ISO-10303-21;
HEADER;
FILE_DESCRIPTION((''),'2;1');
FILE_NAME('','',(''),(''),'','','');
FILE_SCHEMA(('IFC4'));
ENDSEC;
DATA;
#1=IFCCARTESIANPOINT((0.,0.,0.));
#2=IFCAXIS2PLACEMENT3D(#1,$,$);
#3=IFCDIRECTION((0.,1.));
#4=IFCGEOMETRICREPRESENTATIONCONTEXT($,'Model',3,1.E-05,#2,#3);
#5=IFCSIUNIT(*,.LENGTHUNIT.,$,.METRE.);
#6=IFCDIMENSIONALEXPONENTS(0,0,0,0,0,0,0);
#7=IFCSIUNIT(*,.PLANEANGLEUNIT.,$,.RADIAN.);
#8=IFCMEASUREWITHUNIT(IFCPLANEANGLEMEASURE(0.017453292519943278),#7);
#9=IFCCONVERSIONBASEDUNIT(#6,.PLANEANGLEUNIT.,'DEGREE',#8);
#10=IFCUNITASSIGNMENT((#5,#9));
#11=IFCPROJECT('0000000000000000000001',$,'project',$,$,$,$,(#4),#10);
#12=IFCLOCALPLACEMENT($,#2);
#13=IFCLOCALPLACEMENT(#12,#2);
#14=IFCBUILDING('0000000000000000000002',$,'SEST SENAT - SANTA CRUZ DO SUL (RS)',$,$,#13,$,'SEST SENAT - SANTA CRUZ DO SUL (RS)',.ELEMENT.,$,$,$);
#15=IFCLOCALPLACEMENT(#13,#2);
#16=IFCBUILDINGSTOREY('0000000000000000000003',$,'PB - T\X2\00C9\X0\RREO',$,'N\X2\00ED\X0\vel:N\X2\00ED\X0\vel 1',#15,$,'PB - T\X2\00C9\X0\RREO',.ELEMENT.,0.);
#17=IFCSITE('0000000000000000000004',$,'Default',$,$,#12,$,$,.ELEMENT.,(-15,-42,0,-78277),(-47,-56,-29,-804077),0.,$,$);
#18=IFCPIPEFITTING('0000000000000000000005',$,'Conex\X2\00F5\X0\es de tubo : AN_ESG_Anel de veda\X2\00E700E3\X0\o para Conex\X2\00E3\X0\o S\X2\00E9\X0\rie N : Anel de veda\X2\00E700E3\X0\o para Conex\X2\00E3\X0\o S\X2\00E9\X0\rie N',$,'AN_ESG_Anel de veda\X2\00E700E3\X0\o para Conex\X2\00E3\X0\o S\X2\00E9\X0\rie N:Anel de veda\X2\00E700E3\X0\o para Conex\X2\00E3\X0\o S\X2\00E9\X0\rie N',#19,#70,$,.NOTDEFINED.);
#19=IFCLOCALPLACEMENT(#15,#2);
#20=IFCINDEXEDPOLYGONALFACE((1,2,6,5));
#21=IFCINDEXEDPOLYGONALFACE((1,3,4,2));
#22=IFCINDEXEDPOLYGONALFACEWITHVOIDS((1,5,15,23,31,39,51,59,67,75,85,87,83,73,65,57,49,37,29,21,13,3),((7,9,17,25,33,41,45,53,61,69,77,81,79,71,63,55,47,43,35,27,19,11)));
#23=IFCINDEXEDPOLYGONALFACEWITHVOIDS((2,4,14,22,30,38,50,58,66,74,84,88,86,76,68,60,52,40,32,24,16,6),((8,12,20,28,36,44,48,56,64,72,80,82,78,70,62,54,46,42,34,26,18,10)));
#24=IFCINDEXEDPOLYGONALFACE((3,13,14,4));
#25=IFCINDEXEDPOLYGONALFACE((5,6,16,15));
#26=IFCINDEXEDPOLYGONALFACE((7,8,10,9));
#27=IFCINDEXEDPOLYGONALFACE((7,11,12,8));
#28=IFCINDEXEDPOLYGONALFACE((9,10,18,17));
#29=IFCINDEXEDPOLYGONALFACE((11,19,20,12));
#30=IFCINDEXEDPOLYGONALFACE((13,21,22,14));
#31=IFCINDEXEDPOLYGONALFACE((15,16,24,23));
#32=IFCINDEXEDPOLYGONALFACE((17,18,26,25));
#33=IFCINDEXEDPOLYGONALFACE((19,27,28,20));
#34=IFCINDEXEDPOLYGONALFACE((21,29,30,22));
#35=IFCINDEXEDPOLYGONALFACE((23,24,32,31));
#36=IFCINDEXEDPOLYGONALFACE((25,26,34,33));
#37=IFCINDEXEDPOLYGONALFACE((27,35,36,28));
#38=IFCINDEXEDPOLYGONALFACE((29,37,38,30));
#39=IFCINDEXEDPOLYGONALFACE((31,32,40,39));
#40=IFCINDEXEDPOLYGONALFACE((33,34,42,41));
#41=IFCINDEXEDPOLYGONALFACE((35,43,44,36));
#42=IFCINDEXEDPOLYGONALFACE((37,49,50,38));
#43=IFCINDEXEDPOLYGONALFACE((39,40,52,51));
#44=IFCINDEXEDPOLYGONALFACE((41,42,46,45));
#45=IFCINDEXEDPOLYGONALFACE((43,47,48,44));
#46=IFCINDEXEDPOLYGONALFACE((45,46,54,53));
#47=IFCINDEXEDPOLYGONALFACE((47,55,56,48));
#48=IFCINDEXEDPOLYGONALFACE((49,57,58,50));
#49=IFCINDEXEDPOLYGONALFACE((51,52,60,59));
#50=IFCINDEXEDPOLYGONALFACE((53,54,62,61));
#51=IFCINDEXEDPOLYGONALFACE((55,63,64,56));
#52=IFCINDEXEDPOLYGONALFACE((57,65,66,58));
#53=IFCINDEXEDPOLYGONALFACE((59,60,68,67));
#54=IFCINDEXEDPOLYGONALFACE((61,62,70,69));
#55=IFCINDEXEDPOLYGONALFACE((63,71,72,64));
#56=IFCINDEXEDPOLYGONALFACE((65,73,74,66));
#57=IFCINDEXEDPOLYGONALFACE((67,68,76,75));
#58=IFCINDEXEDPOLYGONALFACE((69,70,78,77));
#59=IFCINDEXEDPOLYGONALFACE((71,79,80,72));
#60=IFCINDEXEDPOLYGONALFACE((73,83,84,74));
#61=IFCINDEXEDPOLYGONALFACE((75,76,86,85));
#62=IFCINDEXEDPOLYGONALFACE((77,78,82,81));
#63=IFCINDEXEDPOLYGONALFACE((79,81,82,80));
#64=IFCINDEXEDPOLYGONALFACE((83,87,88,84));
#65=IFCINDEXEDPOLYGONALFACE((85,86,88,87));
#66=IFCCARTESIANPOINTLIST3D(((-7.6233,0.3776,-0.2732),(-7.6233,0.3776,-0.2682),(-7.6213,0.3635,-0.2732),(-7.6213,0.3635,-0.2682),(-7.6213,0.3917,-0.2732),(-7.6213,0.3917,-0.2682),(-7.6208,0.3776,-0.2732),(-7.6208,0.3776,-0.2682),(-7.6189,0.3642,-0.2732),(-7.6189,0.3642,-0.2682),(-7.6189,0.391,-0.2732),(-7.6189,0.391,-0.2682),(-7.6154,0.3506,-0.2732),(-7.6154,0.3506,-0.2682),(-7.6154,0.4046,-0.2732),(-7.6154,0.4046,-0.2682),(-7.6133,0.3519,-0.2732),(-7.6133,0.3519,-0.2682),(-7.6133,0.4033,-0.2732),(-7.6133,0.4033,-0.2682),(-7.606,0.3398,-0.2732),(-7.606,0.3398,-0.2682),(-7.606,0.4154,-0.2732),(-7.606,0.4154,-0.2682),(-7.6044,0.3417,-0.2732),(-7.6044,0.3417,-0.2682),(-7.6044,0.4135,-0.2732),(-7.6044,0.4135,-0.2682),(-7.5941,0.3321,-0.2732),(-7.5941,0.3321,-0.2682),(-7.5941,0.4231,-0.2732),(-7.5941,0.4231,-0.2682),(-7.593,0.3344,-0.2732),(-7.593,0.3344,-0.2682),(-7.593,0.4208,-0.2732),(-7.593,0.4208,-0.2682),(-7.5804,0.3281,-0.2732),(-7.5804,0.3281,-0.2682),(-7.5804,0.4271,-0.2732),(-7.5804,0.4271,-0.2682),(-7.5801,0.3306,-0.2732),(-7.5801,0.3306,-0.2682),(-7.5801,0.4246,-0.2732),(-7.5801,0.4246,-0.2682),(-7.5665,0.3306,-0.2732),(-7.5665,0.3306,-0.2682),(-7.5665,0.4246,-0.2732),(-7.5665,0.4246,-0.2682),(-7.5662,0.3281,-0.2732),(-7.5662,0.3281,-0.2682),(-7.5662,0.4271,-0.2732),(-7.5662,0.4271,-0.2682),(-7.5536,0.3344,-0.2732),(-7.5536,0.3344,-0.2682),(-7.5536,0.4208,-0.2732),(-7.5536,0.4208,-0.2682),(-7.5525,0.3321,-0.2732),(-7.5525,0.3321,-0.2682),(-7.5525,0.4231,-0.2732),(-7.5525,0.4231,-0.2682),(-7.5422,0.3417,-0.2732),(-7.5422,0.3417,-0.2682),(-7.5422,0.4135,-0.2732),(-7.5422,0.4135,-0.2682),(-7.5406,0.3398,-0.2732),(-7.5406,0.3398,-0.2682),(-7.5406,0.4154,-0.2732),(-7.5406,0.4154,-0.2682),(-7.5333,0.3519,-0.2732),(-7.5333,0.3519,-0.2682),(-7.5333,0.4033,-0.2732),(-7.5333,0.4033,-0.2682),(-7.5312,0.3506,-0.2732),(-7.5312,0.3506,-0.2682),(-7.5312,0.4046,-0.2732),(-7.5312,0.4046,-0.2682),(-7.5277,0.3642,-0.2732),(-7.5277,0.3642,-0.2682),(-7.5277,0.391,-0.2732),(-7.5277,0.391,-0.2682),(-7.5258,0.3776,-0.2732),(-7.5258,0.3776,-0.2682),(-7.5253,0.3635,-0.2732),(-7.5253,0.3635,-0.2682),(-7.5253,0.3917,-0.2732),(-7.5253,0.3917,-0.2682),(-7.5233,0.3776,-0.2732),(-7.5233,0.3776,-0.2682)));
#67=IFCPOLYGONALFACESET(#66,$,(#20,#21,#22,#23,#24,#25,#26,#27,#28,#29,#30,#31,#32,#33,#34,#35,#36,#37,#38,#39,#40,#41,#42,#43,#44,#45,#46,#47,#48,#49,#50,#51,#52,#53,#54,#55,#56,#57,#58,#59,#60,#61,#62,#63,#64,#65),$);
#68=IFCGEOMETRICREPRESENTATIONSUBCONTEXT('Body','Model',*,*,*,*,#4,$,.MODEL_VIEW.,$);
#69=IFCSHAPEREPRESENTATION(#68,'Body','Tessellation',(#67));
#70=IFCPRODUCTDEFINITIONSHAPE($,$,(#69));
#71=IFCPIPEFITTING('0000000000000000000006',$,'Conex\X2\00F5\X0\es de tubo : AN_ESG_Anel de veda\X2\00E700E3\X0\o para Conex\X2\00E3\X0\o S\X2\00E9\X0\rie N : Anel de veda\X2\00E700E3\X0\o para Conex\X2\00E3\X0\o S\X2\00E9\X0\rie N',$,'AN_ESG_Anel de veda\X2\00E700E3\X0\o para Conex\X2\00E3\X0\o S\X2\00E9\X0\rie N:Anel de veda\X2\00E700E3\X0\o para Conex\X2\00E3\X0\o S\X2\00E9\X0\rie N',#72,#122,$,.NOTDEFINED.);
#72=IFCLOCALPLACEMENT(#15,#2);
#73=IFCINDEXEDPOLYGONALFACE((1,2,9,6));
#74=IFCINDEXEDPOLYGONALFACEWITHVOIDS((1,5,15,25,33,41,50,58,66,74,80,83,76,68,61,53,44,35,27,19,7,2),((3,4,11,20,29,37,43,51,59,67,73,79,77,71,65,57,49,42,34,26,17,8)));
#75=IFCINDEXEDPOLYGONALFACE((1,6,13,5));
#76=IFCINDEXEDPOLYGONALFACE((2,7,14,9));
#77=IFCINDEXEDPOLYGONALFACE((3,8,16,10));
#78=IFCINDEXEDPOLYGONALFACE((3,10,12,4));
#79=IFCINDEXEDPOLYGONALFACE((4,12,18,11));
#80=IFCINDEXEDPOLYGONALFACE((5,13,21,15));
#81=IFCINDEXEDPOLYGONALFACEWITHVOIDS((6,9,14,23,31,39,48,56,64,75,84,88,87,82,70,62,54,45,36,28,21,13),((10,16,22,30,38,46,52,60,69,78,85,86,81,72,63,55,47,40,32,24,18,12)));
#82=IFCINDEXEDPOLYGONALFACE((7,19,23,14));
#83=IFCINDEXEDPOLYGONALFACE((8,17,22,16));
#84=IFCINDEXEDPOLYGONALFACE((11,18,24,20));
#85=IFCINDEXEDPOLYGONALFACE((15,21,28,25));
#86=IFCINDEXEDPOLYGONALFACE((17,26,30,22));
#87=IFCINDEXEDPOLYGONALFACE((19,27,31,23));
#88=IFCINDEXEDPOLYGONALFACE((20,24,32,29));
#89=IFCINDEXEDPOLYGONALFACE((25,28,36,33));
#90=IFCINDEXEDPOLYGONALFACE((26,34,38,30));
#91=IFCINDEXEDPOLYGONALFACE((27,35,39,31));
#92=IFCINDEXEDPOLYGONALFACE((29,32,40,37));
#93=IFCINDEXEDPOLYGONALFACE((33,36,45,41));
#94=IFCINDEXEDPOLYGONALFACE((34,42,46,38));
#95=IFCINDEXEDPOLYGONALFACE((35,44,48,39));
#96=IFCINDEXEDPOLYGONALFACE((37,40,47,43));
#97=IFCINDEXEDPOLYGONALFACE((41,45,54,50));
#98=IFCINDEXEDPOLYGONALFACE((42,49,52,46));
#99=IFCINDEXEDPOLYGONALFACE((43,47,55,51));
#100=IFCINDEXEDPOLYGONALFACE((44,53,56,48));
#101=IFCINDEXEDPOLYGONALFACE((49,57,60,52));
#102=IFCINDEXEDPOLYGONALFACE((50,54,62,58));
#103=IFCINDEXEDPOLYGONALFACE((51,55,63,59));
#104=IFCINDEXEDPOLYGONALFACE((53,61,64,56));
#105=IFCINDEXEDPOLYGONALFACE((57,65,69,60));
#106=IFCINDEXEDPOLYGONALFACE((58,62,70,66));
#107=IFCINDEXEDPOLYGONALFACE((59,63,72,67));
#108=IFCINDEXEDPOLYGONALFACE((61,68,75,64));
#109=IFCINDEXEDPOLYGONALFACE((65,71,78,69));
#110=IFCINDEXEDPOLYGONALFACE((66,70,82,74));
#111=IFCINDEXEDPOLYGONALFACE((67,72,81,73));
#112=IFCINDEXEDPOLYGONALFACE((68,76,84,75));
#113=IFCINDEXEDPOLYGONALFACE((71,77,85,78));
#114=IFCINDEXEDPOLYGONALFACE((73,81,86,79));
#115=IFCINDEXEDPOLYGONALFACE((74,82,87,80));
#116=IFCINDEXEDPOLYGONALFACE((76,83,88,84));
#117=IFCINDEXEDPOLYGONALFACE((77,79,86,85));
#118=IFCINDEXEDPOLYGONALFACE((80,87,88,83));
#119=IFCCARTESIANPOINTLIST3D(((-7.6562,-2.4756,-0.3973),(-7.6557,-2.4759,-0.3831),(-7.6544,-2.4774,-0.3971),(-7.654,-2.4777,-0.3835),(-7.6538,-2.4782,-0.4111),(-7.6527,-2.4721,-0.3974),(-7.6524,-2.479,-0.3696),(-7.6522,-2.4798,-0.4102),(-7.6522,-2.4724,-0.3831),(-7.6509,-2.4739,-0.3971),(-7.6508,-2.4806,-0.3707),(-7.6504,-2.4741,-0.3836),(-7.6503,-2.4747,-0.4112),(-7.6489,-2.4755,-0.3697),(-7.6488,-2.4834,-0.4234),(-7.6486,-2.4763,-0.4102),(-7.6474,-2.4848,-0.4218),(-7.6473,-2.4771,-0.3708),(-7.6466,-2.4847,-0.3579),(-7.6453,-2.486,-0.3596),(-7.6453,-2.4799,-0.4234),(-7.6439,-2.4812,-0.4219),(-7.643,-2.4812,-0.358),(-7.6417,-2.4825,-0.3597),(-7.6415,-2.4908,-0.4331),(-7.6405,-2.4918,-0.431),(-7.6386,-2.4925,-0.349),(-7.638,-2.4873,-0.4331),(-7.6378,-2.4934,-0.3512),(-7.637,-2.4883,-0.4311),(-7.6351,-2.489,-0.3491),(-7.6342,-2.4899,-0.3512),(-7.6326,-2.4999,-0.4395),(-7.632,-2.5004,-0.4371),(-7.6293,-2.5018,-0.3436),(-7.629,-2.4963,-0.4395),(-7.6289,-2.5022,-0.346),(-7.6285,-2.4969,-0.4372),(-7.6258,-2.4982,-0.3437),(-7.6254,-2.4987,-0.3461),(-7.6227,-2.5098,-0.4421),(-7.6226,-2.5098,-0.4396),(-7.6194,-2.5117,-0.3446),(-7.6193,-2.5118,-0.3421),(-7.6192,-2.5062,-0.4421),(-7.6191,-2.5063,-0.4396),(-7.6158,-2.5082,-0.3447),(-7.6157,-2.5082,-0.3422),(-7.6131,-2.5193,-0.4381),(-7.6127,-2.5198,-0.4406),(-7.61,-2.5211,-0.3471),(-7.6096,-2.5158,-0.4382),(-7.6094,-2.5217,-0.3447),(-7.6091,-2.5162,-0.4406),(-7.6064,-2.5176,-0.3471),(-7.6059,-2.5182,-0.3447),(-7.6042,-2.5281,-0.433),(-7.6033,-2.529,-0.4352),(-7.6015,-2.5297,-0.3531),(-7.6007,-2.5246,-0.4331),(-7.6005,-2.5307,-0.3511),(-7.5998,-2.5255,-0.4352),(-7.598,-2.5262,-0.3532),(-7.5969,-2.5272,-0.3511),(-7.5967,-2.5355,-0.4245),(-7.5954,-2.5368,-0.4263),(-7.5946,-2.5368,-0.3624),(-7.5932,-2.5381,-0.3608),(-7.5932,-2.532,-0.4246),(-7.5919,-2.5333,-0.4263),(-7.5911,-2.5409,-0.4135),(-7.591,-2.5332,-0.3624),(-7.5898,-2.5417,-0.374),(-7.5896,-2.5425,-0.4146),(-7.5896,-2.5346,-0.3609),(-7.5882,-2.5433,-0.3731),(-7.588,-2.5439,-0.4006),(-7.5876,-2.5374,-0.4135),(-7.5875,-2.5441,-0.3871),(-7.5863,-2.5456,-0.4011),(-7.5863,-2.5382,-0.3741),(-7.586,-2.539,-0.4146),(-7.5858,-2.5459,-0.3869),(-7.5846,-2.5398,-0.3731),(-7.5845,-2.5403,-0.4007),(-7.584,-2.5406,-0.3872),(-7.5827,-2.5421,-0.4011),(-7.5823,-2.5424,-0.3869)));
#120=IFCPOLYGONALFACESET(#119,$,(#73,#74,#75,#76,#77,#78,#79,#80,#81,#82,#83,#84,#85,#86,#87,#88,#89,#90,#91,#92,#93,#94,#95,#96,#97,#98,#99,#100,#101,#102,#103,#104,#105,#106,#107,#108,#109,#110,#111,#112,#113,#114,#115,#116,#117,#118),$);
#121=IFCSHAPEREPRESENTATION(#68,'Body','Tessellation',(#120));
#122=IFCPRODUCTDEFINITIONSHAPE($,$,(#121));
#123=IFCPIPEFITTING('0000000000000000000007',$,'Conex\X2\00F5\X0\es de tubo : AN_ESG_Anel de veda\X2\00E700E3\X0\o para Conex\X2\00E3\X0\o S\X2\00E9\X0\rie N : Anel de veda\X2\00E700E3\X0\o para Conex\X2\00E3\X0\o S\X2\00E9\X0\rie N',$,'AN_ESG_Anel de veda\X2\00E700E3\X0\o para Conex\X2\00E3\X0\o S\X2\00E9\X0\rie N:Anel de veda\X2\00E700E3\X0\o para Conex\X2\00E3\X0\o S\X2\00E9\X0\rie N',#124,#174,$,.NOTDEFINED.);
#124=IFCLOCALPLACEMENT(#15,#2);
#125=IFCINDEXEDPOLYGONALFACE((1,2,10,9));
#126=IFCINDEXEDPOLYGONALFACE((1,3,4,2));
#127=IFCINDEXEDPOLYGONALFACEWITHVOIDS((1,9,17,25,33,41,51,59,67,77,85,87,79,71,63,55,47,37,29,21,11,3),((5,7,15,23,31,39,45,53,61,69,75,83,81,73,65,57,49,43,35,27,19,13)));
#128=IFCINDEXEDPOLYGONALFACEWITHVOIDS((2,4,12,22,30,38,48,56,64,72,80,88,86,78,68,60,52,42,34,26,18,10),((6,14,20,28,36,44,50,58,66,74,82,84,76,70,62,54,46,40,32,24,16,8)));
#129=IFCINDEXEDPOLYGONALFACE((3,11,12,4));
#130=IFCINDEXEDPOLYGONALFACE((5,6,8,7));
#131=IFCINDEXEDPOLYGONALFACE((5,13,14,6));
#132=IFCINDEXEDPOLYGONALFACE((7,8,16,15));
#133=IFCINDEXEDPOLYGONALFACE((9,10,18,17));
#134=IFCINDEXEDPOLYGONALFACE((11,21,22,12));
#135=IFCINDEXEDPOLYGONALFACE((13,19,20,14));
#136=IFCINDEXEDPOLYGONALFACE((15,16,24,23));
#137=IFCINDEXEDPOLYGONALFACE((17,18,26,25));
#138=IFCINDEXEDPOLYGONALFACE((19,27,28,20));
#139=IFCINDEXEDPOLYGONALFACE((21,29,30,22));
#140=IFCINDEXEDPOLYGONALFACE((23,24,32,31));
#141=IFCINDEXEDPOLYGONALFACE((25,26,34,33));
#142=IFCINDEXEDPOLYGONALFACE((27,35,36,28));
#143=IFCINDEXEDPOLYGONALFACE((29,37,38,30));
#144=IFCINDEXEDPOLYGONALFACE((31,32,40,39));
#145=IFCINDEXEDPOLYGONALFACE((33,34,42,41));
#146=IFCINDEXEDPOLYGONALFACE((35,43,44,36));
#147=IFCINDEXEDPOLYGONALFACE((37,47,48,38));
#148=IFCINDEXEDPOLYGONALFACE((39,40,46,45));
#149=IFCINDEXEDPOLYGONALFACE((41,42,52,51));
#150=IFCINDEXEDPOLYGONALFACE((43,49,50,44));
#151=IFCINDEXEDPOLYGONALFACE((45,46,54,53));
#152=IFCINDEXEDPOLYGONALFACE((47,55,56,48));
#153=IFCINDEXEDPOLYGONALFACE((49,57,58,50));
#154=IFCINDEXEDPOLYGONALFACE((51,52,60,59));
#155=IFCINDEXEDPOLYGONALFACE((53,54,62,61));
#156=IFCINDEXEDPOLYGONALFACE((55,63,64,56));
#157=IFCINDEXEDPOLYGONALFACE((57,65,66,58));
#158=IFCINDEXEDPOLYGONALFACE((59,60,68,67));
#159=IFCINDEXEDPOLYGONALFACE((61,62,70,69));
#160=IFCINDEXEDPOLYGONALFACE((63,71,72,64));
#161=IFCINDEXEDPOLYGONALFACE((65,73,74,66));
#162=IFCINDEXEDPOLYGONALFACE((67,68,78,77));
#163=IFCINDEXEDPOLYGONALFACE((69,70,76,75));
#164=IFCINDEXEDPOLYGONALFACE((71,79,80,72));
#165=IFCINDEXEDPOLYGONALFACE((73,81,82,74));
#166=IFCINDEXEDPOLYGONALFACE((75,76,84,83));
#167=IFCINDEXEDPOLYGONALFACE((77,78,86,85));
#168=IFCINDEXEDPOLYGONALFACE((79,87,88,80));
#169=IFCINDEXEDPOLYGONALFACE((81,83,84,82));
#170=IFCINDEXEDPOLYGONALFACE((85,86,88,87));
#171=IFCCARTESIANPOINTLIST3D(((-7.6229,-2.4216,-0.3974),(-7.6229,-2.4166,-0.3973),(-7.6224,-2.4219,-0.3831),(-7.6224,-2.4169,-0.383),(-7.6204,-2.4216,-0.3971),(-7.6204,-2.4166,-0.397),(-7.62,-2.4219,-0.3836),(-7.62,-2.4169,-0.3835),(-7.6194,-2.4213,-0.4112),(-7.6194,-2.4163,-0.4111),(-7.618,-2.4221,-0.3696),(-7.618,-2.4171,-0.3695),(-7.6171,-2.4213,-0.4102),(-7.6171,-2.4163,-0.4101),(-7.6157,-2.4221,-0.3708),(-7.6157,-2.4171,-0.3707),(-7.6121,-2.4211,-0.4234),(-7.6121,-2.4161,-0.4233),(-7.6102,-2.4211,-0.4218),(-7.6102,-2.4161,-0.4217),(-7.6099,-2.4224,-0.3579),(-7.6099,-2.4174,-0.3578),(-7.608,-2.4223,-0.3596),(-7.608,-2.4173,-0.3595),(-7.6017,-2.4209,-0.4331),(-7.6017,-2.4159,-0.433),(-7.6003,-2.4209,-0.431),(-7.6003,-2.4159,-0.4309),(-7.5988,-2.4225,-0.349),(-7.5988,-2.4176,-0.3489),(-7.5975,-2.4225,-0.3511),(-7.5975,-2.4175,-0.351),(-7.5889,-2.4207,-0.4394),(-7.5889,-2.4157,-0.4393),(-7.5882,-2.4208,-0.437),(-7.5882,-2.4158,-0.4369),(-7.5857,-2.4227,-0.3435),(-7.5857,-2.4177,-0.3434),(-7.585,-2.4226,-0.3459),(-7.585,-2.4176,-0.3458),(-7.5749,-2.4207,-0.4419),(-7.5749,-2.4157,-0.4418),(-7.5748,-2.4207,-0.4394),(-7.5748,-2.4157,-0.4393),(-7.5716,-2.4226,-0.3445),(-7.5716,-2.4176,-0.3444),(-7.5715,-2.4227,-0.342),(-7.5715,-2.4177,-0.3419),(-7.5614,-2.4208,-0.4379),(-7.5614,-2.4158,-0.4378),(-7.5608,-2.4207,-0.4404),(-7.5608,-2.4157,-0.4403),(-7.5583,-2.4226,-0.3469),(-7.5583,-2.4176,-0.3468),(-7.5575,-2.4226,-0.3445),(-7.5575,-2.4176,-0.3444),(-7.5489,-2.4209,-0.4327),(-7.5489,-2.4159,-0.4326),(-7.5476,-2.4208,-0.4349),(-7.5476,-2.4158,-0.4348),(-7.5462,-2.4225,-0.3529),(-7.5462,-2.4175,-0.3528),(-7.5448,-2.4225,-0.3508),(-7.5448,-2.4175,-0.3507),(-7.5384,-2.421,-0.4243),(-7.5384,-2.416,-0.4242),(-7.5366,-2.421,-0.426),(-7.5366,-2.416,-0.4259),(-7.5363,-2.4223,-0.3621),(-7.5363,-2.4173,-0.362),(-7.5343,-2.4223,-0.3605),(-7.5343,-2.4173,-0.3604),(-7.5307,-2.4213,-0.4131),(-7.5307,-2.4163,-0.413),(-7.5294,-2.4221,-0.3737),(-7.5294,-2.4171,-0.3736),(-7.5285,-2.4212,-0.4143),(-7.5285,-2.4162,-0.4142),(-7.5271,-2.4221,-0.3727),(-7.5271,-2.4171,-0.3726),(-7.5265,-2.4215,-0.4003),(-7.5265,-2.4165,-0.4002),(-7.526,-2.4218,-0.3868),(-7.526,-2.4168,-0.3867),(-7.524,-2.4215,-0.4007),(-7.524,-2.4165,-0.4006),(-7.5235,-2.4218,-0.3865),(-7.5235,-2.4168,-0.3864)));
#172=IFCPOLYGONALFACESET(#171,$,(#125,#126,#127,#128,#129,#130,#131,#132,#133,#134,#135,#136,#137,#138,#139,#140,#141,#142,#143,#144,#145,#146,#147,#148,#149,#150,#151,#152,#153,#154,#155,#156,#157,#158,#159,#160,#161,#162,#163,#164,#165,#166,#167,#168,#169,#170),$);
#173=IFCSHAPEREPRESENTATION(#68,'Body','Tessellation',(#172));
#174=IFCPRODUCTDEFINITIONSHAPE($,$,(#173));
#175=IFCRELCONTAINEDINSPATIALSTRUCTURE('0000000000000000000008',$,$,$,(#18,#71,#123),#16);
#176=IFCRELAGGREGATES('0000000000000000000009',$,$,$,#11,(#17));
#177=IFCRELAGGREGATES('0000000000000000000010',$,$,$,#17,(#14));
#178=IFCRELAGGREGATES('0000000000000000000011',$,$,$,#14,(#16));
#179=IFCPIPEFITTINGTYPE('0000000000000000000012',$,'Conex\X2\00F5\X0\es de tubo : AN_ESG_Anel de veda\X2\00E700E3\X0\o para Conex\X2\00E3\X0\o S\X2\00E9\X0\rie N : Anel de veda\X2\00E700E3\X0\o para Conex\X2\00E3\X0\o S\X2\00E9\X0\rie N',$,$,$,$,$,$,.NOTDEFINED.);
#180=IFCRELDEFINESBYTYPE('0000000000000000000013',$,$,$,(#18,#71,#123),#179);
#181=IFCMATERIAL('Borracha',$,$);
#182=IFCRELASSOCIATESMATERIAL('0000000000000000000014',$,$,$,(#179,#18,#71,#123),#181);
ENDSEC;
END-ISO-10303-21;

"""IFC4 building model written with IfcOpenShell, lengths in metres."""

from ifc_helpers import new_model, entity, si_unit, converted_unit, direction, frame, origin, place, context, subcontext, project, spatial, arc, indexed_curve, outline, extrude, source, transform, mapped, material, type_object, type_shapes, element, save


model = new_model("IFC4")

# Units and contexts
model_context = context("Model", 3, precision=1e-05, world=origin(), true_north=direction((0.0, 1.0)))
body_context = subcontext(model_context, "Body", "Model", "MODEL_VIEW")
ifc_project = project(units=[si_unit("LENGTHUNIT", "METRE"), converted_unit("PLANEANGLEUNIT", "DEGREE", entity("IfcPlaneAngleMeasure", 0.017453292519943278), si_unit("PLANEANGLEUNIT", "RADIAN"), dimensions=[0, 0, 0, 0, 0, 0, 0])], contexts=[model_context])

# Site, building, storey
site_placement = place(None, origin())
site = spatial("IfcSite", under=ifc_project, at=site_placement, Name="Default", CompositionType="ELEMENT", RefLatitude=(-15, -42, 0, -78277), RefLongitude=(-47, -56, -29, -804077), RefElevation=0.0)
building_placement = place(site_placement, origin())
building = spatial("IfcBuilding", under=site, at=building_placement, Name="SEST SENAT - SANTA CRUZ DO SUL (RS)", LongName="SEST SENAT - SANTA CRUZ DO SUL (RS)", CompositionType="ELEMENT")
storey_placement = place(building_placement, origin())
storey = spatial("IfcBuildingStorey", under=building, at=storey_placement, Name="PB - TÉRREO", ObjectType="Nível:Nível 1", LongName="PB - TÉRREO", CompositionType="ELEMENT", Elevation=0.0)

# Pipe fittings
ifc_material_1 = material(Name="Borracha")
pipe_fitting_type_1 = type_object("IfcPipeFittingType", Name="Conexões de tubo : AN_ESG_Anel de vedação para Conexão Série N : Anel de vedação para Conexão Série N", PredefinedType="NOTDEFINED", material=ifc_material_1)
shared_shape_1 = source(origin(), body_context, "Body", "SweptSolid", [
    extrude(outline(indexed_curve([(-0.05, 0.0), (0.0, -0.05), (0.05, 0.0), (0.0, 0.05)], segments=[arc(1, 2, 3), arc(3, 4, 1)], self_intersect=False), holes=[indexed_curve([(-0.0475, 0.0), (0.0, 0.0475), (0.0475, 0.0), (0.0, -0.0475)], segments=[arc(1, 2, 3), arc(3, 4, 1)], self_intersect=False)]), frame((0.0, 0.0, -0.005)), (0.0, 0.0, 1.0), 0.005),
])
type_shapes(pipe_fitting_type_1, [shared_shape_1])
for number, where, z_axis, x_axis, name in (
    (1, (-7.5733, 0.3776, -0.2732), (0.000058, -0.000034, -1.0), (1.0, 0.000009, 0.000058), "Conexões de tubo : AN_ESG_Anel de vedação para Conexão Série N : Anel de vedação para Conexão Série N"),
    (2, (-7.621, -2.5108, -0.3921), (-0.707071, -0.707072, 0.01), (0.034096, -0.019965, 0.999219), "Conexões de tubo : AN_ESG_Anel de vedação para Conexão Série N : Anel de vedação para Conexão Série N"),
    (3, (-7.5732, -2.4217, -0.3919), (-0.000014, -0.9998, -0.019976), (0.034096, -0.019965, 0.999219), "Conexões de tubo : AN_ESG_Anel de vedação para Conexão Série N : Anel de vedação para Conexão Série N"),
):
    element("IfcPipeFitting", number, at=place(storey_placement, frame(where, z_axis=z_axis, x_axis=x_axis)), inside=storey, type_object=pipe_fitting_type_1, material=ifc_material_1, Name=name, ObjectType="AN_ESG_Anel de vedação para Conexão Série N:Anel de vedação para Conexão Série N", PredefinedType="NOTDEFINED", context=body_context, shape_type="MappedRepresentation", body=[
        mapped(shared_shape_1, transform((0.0, 0.0, 0.0), scale=1.0)),
    ])

save(model, "model.ifc")
